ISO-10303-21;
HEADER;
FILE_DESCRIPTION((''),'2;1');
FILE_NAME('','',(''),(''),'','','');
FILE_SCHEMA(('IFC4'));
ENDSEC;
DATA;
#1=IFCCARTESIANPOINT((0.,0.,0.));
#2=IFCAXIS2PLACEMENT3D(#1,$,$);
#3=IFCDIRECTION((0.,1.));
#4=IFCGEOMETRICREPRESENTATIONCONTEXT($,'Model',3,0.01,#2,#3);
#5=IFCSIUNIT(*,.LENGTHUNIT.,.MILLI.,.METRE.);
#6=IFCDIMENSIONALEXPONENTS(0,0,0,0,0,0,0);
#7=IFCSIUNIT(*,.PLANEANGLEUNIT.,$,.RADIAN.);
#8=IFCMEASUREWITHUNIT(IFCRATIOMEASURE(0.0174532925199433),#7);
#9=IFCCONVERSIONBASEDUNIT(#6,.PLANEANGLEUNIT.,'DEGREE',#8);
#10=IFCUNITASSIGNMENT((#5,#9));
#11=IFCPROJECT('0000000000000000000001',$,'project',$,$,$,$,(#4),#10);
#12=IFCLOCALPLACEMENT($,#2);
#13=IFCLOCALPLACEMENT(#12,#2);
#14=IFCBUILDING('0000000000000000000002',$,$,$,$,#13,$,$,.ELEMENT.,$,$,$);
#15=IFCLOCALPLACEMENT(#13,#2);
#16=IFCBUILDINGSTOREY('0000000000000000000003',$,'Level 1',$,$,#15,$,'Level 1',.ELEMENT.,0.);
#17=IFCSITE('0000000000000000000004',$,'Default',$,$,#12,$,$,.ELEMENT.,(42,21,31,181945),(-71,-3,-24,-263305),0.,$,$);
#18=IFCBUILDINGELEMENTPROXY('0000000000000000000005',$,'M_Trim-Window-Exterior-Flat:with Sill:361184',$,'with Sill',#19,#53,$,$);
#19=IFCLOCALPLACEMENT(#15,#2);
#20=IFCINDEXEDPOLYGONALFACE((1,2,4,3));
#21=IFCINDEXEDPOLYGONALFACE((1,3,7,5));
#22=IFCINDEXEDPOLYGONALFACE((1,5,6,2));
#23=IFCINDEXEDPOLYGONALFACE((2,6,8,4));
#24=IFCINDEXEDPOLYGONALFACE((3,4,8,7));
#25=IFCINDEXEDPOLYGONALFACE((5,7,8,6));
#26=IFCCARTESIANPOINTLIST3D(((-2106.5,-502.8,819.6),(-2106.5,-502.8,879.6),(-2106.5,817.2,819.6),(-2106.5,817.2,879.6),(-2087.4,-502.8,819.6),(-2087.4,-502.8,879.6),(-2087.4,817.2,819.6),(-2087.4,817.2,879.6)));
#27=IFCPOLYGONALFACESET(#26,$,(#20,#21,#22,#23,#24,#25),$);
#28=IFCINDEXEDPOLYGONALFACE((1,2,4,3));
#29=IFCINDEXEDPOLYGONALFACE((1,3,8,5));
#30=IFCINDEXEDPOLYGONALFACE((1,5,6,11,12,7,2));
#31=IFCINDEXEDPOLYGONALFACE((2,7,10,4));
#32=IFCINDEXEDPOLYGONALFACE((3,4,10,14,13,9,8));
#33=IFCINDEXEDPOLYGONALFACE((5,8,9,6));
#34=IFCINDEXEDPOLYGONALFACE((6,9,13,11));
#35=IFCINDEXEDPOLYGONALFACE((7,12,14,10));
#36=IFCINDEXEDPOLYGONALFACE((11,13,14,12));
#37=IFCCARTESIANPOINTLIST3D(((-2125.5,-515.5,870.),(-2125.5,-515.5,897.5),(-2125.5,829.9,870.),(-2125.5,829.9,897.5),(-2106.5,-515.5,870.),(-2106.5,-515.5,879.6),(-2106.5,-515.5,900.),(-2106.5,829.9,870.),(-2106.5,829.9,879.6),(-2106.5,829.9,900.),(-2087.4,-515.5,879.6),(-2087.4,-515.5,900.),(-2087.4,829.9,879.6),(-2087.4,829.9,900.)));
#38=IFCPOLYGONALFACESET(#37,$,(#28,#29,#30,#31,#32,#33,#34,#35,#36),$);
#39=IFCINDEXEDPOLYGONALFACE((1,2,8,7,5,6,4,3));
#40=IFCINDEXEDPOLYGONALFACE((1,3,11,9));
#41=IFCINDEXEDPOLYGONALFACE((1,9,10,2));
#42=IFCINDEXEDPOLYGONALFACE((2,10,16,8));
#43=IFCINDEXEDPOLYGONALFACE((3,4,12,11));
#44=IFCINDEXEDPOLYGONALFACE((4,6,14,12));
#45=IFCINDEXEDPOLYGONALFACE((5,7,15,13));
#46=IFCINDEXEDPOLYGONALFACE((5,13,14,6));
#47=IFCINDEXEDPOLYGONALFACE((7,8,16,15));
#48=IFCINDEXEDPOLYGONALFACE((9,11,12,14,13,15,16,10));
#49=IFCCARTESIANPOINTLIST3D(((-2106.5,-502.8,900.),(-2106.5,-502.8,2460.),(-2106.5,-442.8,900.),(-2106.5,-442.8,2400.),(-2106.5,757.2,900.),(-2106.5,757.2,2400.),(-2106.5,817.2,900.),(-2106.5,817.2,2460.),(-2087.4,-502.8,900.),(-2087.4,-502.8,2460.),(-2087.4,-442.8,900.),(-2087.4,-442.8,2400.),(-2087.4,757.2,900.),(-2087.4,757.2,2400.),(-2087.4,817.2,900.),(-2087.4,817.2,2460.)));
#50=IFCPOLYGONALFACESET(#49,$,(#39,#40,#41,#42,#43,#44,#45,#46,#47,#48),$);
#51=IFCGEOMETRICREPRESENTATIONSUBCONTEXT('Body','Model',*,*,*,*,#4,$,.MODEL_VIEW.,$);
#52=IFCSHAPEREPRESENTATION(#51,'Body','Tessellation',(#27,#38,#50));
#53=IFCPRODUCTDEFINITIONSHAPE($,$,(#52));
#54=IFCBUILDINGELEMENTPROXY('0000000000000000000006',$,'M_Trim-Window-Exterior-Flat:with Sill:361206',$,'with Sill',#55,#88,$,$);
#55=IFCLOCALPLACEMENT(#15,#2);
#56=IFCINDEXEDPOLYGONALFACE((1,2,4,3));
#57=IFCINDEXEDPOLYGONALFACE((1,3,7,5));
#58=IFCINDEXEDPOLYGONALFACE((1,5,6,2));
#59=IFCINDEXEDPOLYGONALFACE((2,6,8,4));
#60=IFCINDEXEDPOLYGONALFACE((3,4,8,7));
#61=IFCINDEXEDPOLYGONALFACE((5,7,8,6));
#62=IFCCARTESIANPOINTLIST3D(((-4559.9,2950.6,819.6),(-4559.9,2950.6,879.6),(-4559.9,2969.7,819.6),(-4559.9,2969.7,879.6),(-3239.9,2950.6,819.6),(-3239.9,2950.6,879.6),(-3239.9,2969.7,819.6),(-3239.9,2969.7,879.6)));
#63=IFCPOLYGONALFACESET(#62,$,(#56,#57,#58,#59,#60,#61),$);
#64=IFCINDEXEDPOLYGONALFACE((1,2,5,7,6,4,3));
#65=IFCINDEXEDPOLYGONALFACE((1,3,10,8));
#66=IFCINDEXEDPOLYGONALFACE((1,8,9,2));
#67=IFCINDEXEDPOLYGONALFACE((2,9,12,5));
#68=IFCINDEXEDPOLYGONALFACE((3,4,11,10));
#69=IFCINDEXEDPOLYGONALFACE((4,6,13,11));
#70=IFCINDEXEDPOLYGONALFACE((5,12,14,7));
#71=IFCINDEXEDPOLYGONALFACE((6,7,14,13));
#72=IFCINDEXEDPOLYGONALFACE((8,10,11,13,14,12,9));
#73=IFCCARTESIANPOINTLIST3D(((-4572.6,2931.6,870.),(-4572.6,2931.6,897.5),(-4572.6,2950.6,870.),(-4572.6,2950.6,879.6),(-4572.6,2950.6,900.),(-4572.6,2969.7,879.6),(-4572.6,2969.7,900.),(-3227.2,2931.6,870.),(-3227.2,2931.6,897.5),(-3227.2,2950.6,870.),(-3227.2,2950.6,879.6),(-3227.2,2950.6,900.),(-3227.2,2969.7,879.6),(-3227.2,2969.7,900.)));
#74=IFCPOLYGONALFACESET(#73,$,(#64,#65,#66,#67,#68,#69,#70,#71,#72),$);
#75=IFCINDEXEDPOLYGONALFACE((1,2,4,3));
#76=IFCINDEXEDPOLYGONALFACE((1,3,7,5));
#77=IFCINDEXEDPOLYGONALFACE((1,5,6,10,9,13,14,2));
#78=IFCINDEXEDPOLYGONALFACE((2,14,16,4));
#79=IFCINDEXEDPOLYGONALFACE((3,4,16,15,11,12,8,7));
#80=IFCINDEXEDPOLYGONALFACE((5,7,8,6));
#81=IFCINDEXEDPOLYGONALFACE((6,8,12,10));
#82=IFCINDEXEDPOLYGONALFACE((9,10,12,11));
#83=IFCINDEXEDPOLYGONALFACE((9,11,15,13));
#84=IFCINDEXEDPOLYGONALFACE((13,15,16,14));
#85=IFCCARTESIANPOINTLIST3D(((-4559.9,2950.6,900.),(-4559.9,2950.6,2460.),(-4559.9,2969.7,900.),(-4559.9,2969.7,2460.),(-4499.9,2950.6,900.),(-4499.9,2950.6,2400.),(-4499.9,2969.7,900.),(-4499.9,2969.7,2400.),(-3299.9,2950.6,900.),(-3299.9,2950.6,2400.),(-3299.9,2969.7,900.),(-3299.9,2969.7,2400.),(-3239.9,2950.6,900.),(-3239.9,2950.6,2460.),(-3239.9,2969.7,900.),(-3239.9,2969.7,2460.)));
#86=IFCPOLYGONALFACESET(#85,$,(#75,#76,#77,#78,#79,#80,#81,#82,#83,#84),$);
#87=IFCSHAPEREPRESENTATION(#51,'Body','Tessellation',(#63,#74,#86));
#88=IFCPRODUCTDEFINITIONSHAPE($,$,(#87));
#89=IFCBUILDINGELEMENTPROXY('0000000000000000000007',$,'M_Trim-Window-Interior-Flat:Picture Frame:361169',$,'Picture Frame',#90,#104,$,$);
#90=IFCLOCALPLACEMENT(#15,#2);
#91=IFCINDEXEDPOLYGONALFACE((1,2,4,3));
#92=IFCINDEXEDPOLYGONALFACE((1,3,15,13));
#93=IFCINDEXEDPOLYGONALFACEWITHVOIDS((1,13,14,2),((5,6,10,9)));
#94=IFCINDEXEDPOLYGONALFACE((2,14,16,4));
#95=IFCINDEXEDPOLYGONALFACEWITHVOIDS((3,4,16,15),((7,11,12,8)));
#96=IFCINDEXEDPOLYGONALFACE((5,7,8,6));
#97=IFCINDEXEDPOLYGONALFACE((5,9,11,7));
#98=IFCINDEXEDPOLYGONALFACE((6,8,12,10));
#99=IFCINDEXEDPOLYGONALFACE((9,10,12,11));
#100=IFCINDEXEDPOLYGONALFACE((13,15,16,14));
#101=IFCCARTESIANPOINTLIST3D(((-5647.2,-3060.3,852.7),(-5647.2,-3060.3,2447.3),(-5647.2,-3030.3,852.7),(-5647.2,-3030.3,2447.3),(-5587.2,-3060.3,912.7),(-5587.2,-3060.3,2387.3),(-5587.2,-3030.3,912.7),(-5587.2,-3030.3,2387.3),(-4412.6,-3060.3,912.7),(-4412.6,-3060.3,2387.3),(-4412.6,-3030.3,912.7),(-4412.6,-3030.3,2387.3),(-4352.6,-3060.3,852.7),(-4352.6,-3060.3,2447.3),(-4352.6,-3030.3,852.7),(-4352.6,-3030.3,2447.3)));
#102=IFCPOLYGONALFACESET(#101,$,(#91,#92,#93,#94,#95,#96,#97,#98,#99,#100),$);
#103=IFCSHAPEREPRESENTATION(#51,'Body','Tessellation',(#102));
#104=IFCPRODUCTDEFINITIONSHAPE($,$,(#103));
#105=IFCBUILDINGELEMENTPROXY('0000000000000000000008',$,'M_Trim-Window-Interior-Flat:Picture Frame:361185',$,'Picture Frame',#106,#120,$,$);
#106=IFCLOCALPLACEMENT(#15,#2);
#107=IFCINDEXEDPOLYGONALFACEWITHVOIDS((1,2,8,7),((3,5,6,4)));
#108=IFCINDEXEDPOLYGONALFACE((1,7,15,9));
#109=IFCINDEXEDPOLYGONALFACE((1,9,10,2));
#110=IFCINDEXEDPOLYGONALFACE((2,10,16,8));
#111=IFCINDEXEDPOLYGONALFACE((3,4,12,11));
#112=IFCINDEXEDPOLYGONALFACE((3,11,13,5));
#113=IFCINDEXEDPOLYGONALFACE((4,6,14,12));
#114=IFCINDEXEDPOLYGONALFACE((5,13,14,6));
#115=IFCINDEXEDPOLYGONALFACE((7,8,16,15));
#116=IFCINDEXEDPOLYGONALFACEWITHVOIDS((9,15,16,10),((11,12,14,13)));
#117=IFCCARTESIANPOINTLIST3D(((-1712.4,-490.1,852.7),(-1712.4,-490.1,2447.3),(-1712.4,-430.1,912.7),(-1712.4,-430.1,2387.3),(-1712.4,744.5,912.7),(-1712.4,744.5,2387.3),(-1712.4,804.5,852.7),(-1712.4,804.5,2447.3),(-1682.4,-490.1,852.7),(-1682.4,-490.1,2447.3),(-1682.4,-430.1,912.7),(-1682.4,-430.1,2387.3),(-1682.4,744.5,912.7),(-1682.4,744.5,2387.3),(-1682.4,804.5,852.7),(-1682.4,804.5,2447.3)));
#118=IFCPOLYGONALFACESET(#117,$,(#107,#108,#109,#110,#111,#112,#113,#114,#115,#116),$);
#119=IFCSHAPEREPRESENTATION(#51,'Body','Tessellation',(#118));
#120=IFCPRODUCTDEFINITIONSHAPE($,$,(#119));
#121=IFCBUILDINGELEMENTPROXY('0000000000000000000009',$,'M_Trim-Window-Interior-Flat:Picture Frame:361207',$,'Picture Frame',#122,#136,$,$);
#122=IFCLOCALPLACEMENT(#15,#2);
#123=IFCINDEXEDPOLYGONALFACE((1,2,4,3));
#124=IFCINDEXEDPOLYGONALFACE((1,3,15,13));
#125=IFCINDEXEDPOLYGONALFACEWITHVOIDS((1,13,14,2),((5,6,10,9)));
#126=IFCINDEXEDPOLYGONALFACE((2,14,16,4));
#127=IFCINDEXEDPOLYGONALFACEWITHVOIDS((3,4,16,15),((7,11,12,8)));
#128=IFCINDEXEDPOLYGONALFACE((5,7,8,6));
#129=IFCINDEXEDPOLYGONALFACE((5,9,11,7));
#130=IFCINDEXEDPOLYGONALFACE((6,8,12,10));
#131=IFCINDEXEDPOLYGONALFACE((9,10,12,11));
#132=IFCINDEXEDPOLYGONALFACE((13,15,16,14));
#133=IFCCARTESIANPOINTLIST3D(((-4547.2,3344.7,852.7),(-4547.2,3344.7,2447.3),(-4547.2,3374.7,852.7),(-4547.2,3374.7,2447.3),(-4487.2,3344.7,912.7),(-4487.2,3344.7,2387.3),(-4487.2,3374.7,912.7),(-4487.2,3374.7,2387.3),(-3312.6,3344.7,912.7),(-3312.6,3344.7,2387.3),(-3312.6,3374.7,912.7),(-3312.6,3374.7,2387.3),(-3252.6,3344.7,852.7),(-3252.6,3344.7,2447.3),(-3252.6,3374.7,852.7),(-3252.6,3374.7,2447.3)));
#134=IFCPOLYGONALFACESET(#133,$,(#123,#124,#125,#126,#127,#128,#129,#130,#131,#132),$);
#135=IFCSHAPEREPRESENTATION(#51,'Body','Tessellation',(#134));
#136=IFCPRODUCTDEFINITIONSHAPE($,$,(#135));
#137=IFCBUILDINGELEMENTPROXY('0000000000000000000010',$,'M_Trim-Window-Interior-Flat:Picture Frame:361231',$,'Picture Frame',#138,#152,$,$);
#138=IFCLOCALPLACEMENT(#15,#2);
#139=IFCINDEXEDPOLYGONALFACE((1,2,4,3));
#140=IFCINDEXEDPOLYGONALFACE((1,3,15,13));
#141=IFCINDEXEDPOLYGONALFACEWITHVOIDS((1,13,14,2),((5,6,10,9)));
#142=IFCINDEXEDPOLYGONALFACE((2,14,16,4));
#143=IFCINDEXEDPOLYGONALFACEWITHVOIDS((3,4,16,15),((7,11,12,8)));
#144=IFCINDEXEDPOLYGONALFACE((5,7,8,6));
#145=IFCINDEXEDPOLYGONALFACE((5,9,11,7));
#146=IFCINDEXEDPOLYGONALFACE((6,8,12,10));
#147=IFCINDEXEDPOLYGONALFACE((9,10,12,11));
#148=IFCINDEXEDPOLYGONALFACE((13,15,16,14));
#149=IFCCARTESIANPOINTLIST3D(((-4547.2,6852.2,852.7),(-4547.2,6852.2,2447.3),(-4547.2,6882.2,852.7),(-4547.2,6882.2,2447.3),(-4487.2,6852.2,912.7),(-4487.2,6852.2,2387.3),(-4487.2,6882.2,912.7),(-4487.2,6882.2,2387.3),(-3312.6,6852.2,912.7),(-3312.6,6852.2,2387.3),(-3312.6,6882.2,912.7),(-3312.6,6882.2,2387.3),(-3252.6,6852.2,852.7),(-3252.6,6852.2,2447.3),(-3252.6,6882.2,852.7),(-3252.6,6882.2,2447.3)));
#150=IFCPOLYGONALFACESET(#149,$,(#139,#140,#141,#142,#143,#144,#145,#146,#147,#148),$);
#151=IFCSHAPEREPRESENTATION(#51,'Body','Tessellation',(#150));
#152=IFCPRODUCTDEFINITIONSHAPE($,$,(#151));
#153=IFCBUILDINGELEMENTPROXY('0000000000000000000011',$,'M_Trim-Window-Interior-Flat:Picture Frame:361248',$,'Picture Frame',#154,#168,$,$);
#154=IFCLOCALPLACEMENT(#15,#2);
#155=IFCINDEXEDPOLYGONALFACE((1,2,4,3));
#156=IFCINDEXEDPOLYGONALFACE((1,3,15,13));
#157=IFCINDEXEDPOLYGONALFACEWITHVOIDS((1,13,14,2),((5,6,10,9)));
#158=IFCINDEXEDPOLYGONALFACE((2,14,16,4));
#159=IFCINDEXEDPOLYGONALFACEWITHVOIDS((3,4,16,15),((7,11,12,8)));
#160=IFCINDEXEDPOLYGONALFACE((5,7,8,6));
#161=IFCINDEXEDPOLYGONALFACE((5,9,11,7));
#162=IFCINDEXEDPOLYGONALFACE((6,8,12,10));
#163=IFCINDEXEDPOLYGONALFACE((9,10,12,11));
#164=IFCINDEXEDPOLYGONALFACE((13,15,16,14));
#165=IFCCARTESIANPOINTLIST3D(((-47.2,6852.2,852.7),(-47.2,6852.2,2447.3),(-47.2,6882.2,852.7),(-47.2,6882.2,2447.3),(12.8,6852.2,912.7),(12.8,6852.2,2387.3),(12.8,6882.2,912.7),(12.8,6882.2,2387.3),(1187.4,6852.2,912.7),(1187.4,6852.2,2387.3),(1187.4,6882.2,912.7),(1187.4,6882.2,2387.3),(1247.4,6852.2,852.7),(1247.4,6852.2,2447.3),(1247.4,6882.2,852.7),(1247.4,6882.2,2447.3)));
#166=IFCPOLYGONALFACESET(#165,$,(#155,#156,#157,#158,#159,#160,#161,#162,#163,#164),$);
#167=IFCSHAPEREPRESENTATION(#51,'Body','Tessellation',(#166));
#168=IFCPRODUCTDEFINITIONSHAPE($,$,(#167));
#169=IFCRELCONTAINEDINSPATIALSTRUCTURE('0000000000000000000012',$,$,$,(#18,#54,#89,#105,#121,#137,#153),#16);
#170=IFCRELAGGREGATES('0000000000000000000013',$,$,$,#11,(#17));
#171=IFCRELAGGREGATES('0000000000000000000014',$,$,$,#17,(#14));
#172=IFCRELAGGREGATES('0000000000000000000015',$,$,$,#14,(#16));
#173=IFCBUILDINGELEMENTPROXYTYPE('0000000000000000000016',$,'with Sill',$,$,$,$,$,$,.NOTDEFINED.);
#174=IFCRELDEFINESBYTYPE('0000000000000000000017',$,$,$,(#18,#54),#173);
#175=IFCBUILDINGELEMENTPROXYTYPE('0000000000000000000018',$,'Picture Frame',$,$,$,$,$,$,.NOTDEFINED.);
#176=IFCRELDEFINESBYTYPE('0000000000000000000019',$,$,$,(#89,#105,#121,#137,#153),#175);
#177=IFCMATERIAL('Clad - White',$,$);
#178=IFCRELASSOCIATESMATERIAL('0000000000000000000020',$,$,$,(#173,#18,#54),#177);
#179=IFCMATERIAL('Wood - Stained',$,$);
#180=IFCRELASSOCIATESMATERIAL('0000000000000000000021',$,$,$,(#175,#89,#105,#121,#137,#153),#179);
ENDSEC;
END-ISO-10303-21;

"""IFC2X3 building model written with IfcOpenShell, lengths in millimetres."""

from ifc_helpers import new_model, entity, si_unit, converted_unit, direction, frame, frame_2d, origin, place, context, subcontext, project, spatial, polyline, rectangle, outline, extrude, source, transform, mapped, material, type_object, type_shapes, element, save


model = new_model("IFC2X3")

# Units and contexts
model_context = context("Model", 3, precision=0.01, world=origin(), true_north=direction((0.0, 1.0)))
body_context = subcontext(model_context, "Body", "Model", "MODEL_VIEW")
ifc_project = project(units=[si_unit("LENGTHUNIT", "METRE", prefix="MILLI"), converted_unit("PLANEANGLEUNIT", "DEGREE", entity("IfcRatioMeasure", 0.0174532925199433), si_unit("PLANEANGLEUNIT", "RADIAN"), dimensions=[0, 0, 0, 0, 0, 0, 0])], contexts=[model_context])

# Site, building, storey
site_placement = place(None, origin())
site = spatial("IfcSite", under=ifc_project, at=site_placement, Name="Default", CompositionType="ELEMENT", RefLatitude=(42, 21, 31, 181945), RefLongitude=(-71, -3, -24, -263305), RefElevation=0.0)
building_placement = place(site_placement, origin())
building = spatial("IfcBuilding", under=site, at=building_placement, CompositionType="ELEMENT")
storey_placement = place(building_placement, origin())
storey = spatial("IfcBuildingStorey", under=building, at=storey_placement, Name="Level 1", LongName="Level 1", CompositionType="ELEMENT", Elevation=0.0)

# Building element proxies
ifc_material_1 = material(Name="Clad - White")
ifc_material_2 = material(Name="Wood - Stained")
building_element_proxy_type_1 = type_object("IfcBuildingElementProxyType", Name="with Sill", PredefinedType="NOTDEFINED", material=ifc_material_1)
shared_shape_1 = source(origin(), body_context, "Body", "SweptSolid", [
    extrude(rectangle(XDim=1320.0, YDim=60.0, at=frame_2d((0.0, 0.0), x_axis=(1.0, 0.0))), frame((0.0, -1550.4, 0.0), z_axis=(0.0, 0.0, 1.0), x_axis=(-1.0, 0.0, 0.0)), (0.0, 0.0, 1.0), 19.1),
    extrude(outline(polyline([(-19.0, -15.2), (0.0, -15.2), (0.0, -5.7), (19.0, -5.7), (19.0, 14.8), (0.0, 14.8), (-19.0, 12.3), (-19.0, -15.2)])), frame((-672.7, -1514.8, 19.0), z_axis=(1.0, 0.0, 0.0), x_axis=(0.0, 0.0, -1.0)), (0.0, 0.0, 1.0), 1345.4),
    extrude(outline(polyline([(-795.0, -660.0), (765.0, -660.0), (765.0, -600.0), (-735.0, -600.0), (-735.0, 600.0), (765.0, 600.0), (765.0, 660.0), (-795.0, 660.0), (-795.0, -660.0)])), frame((0.0, -735.0, 0.0), z_axis=(0.0, 0.0, 1.0), x_axis=(0.0, -1.0, 0.0)), (0.0, 0.0, 1.0), 19.1),
])
type_shapes(building_element_proxy_type_1, [shared_shape_1])
for number, where, z_axis, x_axis, name in (
    (1, (-2087.4, 157.2, 2400.0), (-1.0, 0.0, 0.0), (0.0, -1.0, 0.0), "M_Trim-Window-Exterior-Flat:with Sill:361184"),
    (2, (-3899.9, 2969.7, 2400.0), (0.0, -1.0, 0.0), (1.0, 0.0, 0.0), "M_Trim-Window-Exterior-Flat:with Sill:361206"),
):
    element("IfcBuildingElementProxy", number, at=place(storey_placement, frame(where, z_axis=z_axis, x_axis=x_axis)), inside=storey, type_object=building_element_proxy_type_1, material=ifc_material_1, Name=name, ObjectType="with Sill", context=body_context, shape_type="MappedRepresentation", body=[
        mapped(shared_shape_1, transform((0.0, 0.0, 0.0), scale=1.0)),
    ])
building_element_proxy_type_2 = type_object("IfcBuildingElementProxyType", Name="Picture Frame", PredefinedType="NOTDEFINED", material=ifc_material_2)
shared_shape_2 = source(origin(), body_context, "Body", "SweptSolid", [
    extrude(outline(polyline([(-647.3, -797.3), (647.3, -797.3), (647.3, 797.3), (-647.3, 797.3), (-647.3, -797.3)]), holes=[polyline([(-587.3, -737.3), (-587.3, 737.3), (587.3, 737.3), (587.3, -737.3), (-587.3, -737.3)])]), frame((0.0, -750.0, 0.0), z_axis=(0.0, 0.0, 1.0), x_axis=(-1.0, 0.0, 0.0)), (0.0, 0.0, 1.0), 30.0),
])
type_shapes(building_element_proxy_type_2, [shared_shape_2])
for number, where, z_axis, x_axis, name in (
    (3, (-4999.9, -3030.3, 2400.0), (0.0, -1.0, 0.0), (1.0, 0.0, 0.0), "M_Trim-Window-Interior-Flat:Picture Frame:361169"),
    (4, (-1712.4, 157.2, 2400.0), (1.0, 0.0, 0.0), (0.0, 1.0, 0.0), "M_Trim-Window-Interior-Flat:Picture Frame:361185"),
    (5, (-3899.9, 3344.7, 2400.0), (0.0, 1.0, 0.0), (-1.0, 0.0, 0.0), "M_Trim-Window-Interior-Flat:Picture Frame:361207"),
    (6, (-3899.9, 6882.2, 2400.0), (0.0, -1.0, 0.0), (1.0, 0.0, 0.0), "M_Trim-Window-Interior-Flat:Picture Frame:361231"),
    (7, (600.1, 6882.2, 2400.0), (0.0, -1.0, 0.0), (1.0, 0.0, 0.0), "M_Trim-Window-Interior-Flat:Picture Frame:361248"),
):
    element("IfcBuildingElementProxy", number, at=place(storey_placement, frame(where, z_axis=z_axis, x_axis=x_axis)), inside=storey, type_object=building_element_proxy_type_2, material=ifc_material_2, Name=name, ObjectType="Picture Frame", context=body_context, shape_type="MappedRepresentation", body=[
        mapped(shared_shape_2, transform((0.0, 0.0, 0.0), scale=1.0)),
    ])

save(model, "model.ifc")
